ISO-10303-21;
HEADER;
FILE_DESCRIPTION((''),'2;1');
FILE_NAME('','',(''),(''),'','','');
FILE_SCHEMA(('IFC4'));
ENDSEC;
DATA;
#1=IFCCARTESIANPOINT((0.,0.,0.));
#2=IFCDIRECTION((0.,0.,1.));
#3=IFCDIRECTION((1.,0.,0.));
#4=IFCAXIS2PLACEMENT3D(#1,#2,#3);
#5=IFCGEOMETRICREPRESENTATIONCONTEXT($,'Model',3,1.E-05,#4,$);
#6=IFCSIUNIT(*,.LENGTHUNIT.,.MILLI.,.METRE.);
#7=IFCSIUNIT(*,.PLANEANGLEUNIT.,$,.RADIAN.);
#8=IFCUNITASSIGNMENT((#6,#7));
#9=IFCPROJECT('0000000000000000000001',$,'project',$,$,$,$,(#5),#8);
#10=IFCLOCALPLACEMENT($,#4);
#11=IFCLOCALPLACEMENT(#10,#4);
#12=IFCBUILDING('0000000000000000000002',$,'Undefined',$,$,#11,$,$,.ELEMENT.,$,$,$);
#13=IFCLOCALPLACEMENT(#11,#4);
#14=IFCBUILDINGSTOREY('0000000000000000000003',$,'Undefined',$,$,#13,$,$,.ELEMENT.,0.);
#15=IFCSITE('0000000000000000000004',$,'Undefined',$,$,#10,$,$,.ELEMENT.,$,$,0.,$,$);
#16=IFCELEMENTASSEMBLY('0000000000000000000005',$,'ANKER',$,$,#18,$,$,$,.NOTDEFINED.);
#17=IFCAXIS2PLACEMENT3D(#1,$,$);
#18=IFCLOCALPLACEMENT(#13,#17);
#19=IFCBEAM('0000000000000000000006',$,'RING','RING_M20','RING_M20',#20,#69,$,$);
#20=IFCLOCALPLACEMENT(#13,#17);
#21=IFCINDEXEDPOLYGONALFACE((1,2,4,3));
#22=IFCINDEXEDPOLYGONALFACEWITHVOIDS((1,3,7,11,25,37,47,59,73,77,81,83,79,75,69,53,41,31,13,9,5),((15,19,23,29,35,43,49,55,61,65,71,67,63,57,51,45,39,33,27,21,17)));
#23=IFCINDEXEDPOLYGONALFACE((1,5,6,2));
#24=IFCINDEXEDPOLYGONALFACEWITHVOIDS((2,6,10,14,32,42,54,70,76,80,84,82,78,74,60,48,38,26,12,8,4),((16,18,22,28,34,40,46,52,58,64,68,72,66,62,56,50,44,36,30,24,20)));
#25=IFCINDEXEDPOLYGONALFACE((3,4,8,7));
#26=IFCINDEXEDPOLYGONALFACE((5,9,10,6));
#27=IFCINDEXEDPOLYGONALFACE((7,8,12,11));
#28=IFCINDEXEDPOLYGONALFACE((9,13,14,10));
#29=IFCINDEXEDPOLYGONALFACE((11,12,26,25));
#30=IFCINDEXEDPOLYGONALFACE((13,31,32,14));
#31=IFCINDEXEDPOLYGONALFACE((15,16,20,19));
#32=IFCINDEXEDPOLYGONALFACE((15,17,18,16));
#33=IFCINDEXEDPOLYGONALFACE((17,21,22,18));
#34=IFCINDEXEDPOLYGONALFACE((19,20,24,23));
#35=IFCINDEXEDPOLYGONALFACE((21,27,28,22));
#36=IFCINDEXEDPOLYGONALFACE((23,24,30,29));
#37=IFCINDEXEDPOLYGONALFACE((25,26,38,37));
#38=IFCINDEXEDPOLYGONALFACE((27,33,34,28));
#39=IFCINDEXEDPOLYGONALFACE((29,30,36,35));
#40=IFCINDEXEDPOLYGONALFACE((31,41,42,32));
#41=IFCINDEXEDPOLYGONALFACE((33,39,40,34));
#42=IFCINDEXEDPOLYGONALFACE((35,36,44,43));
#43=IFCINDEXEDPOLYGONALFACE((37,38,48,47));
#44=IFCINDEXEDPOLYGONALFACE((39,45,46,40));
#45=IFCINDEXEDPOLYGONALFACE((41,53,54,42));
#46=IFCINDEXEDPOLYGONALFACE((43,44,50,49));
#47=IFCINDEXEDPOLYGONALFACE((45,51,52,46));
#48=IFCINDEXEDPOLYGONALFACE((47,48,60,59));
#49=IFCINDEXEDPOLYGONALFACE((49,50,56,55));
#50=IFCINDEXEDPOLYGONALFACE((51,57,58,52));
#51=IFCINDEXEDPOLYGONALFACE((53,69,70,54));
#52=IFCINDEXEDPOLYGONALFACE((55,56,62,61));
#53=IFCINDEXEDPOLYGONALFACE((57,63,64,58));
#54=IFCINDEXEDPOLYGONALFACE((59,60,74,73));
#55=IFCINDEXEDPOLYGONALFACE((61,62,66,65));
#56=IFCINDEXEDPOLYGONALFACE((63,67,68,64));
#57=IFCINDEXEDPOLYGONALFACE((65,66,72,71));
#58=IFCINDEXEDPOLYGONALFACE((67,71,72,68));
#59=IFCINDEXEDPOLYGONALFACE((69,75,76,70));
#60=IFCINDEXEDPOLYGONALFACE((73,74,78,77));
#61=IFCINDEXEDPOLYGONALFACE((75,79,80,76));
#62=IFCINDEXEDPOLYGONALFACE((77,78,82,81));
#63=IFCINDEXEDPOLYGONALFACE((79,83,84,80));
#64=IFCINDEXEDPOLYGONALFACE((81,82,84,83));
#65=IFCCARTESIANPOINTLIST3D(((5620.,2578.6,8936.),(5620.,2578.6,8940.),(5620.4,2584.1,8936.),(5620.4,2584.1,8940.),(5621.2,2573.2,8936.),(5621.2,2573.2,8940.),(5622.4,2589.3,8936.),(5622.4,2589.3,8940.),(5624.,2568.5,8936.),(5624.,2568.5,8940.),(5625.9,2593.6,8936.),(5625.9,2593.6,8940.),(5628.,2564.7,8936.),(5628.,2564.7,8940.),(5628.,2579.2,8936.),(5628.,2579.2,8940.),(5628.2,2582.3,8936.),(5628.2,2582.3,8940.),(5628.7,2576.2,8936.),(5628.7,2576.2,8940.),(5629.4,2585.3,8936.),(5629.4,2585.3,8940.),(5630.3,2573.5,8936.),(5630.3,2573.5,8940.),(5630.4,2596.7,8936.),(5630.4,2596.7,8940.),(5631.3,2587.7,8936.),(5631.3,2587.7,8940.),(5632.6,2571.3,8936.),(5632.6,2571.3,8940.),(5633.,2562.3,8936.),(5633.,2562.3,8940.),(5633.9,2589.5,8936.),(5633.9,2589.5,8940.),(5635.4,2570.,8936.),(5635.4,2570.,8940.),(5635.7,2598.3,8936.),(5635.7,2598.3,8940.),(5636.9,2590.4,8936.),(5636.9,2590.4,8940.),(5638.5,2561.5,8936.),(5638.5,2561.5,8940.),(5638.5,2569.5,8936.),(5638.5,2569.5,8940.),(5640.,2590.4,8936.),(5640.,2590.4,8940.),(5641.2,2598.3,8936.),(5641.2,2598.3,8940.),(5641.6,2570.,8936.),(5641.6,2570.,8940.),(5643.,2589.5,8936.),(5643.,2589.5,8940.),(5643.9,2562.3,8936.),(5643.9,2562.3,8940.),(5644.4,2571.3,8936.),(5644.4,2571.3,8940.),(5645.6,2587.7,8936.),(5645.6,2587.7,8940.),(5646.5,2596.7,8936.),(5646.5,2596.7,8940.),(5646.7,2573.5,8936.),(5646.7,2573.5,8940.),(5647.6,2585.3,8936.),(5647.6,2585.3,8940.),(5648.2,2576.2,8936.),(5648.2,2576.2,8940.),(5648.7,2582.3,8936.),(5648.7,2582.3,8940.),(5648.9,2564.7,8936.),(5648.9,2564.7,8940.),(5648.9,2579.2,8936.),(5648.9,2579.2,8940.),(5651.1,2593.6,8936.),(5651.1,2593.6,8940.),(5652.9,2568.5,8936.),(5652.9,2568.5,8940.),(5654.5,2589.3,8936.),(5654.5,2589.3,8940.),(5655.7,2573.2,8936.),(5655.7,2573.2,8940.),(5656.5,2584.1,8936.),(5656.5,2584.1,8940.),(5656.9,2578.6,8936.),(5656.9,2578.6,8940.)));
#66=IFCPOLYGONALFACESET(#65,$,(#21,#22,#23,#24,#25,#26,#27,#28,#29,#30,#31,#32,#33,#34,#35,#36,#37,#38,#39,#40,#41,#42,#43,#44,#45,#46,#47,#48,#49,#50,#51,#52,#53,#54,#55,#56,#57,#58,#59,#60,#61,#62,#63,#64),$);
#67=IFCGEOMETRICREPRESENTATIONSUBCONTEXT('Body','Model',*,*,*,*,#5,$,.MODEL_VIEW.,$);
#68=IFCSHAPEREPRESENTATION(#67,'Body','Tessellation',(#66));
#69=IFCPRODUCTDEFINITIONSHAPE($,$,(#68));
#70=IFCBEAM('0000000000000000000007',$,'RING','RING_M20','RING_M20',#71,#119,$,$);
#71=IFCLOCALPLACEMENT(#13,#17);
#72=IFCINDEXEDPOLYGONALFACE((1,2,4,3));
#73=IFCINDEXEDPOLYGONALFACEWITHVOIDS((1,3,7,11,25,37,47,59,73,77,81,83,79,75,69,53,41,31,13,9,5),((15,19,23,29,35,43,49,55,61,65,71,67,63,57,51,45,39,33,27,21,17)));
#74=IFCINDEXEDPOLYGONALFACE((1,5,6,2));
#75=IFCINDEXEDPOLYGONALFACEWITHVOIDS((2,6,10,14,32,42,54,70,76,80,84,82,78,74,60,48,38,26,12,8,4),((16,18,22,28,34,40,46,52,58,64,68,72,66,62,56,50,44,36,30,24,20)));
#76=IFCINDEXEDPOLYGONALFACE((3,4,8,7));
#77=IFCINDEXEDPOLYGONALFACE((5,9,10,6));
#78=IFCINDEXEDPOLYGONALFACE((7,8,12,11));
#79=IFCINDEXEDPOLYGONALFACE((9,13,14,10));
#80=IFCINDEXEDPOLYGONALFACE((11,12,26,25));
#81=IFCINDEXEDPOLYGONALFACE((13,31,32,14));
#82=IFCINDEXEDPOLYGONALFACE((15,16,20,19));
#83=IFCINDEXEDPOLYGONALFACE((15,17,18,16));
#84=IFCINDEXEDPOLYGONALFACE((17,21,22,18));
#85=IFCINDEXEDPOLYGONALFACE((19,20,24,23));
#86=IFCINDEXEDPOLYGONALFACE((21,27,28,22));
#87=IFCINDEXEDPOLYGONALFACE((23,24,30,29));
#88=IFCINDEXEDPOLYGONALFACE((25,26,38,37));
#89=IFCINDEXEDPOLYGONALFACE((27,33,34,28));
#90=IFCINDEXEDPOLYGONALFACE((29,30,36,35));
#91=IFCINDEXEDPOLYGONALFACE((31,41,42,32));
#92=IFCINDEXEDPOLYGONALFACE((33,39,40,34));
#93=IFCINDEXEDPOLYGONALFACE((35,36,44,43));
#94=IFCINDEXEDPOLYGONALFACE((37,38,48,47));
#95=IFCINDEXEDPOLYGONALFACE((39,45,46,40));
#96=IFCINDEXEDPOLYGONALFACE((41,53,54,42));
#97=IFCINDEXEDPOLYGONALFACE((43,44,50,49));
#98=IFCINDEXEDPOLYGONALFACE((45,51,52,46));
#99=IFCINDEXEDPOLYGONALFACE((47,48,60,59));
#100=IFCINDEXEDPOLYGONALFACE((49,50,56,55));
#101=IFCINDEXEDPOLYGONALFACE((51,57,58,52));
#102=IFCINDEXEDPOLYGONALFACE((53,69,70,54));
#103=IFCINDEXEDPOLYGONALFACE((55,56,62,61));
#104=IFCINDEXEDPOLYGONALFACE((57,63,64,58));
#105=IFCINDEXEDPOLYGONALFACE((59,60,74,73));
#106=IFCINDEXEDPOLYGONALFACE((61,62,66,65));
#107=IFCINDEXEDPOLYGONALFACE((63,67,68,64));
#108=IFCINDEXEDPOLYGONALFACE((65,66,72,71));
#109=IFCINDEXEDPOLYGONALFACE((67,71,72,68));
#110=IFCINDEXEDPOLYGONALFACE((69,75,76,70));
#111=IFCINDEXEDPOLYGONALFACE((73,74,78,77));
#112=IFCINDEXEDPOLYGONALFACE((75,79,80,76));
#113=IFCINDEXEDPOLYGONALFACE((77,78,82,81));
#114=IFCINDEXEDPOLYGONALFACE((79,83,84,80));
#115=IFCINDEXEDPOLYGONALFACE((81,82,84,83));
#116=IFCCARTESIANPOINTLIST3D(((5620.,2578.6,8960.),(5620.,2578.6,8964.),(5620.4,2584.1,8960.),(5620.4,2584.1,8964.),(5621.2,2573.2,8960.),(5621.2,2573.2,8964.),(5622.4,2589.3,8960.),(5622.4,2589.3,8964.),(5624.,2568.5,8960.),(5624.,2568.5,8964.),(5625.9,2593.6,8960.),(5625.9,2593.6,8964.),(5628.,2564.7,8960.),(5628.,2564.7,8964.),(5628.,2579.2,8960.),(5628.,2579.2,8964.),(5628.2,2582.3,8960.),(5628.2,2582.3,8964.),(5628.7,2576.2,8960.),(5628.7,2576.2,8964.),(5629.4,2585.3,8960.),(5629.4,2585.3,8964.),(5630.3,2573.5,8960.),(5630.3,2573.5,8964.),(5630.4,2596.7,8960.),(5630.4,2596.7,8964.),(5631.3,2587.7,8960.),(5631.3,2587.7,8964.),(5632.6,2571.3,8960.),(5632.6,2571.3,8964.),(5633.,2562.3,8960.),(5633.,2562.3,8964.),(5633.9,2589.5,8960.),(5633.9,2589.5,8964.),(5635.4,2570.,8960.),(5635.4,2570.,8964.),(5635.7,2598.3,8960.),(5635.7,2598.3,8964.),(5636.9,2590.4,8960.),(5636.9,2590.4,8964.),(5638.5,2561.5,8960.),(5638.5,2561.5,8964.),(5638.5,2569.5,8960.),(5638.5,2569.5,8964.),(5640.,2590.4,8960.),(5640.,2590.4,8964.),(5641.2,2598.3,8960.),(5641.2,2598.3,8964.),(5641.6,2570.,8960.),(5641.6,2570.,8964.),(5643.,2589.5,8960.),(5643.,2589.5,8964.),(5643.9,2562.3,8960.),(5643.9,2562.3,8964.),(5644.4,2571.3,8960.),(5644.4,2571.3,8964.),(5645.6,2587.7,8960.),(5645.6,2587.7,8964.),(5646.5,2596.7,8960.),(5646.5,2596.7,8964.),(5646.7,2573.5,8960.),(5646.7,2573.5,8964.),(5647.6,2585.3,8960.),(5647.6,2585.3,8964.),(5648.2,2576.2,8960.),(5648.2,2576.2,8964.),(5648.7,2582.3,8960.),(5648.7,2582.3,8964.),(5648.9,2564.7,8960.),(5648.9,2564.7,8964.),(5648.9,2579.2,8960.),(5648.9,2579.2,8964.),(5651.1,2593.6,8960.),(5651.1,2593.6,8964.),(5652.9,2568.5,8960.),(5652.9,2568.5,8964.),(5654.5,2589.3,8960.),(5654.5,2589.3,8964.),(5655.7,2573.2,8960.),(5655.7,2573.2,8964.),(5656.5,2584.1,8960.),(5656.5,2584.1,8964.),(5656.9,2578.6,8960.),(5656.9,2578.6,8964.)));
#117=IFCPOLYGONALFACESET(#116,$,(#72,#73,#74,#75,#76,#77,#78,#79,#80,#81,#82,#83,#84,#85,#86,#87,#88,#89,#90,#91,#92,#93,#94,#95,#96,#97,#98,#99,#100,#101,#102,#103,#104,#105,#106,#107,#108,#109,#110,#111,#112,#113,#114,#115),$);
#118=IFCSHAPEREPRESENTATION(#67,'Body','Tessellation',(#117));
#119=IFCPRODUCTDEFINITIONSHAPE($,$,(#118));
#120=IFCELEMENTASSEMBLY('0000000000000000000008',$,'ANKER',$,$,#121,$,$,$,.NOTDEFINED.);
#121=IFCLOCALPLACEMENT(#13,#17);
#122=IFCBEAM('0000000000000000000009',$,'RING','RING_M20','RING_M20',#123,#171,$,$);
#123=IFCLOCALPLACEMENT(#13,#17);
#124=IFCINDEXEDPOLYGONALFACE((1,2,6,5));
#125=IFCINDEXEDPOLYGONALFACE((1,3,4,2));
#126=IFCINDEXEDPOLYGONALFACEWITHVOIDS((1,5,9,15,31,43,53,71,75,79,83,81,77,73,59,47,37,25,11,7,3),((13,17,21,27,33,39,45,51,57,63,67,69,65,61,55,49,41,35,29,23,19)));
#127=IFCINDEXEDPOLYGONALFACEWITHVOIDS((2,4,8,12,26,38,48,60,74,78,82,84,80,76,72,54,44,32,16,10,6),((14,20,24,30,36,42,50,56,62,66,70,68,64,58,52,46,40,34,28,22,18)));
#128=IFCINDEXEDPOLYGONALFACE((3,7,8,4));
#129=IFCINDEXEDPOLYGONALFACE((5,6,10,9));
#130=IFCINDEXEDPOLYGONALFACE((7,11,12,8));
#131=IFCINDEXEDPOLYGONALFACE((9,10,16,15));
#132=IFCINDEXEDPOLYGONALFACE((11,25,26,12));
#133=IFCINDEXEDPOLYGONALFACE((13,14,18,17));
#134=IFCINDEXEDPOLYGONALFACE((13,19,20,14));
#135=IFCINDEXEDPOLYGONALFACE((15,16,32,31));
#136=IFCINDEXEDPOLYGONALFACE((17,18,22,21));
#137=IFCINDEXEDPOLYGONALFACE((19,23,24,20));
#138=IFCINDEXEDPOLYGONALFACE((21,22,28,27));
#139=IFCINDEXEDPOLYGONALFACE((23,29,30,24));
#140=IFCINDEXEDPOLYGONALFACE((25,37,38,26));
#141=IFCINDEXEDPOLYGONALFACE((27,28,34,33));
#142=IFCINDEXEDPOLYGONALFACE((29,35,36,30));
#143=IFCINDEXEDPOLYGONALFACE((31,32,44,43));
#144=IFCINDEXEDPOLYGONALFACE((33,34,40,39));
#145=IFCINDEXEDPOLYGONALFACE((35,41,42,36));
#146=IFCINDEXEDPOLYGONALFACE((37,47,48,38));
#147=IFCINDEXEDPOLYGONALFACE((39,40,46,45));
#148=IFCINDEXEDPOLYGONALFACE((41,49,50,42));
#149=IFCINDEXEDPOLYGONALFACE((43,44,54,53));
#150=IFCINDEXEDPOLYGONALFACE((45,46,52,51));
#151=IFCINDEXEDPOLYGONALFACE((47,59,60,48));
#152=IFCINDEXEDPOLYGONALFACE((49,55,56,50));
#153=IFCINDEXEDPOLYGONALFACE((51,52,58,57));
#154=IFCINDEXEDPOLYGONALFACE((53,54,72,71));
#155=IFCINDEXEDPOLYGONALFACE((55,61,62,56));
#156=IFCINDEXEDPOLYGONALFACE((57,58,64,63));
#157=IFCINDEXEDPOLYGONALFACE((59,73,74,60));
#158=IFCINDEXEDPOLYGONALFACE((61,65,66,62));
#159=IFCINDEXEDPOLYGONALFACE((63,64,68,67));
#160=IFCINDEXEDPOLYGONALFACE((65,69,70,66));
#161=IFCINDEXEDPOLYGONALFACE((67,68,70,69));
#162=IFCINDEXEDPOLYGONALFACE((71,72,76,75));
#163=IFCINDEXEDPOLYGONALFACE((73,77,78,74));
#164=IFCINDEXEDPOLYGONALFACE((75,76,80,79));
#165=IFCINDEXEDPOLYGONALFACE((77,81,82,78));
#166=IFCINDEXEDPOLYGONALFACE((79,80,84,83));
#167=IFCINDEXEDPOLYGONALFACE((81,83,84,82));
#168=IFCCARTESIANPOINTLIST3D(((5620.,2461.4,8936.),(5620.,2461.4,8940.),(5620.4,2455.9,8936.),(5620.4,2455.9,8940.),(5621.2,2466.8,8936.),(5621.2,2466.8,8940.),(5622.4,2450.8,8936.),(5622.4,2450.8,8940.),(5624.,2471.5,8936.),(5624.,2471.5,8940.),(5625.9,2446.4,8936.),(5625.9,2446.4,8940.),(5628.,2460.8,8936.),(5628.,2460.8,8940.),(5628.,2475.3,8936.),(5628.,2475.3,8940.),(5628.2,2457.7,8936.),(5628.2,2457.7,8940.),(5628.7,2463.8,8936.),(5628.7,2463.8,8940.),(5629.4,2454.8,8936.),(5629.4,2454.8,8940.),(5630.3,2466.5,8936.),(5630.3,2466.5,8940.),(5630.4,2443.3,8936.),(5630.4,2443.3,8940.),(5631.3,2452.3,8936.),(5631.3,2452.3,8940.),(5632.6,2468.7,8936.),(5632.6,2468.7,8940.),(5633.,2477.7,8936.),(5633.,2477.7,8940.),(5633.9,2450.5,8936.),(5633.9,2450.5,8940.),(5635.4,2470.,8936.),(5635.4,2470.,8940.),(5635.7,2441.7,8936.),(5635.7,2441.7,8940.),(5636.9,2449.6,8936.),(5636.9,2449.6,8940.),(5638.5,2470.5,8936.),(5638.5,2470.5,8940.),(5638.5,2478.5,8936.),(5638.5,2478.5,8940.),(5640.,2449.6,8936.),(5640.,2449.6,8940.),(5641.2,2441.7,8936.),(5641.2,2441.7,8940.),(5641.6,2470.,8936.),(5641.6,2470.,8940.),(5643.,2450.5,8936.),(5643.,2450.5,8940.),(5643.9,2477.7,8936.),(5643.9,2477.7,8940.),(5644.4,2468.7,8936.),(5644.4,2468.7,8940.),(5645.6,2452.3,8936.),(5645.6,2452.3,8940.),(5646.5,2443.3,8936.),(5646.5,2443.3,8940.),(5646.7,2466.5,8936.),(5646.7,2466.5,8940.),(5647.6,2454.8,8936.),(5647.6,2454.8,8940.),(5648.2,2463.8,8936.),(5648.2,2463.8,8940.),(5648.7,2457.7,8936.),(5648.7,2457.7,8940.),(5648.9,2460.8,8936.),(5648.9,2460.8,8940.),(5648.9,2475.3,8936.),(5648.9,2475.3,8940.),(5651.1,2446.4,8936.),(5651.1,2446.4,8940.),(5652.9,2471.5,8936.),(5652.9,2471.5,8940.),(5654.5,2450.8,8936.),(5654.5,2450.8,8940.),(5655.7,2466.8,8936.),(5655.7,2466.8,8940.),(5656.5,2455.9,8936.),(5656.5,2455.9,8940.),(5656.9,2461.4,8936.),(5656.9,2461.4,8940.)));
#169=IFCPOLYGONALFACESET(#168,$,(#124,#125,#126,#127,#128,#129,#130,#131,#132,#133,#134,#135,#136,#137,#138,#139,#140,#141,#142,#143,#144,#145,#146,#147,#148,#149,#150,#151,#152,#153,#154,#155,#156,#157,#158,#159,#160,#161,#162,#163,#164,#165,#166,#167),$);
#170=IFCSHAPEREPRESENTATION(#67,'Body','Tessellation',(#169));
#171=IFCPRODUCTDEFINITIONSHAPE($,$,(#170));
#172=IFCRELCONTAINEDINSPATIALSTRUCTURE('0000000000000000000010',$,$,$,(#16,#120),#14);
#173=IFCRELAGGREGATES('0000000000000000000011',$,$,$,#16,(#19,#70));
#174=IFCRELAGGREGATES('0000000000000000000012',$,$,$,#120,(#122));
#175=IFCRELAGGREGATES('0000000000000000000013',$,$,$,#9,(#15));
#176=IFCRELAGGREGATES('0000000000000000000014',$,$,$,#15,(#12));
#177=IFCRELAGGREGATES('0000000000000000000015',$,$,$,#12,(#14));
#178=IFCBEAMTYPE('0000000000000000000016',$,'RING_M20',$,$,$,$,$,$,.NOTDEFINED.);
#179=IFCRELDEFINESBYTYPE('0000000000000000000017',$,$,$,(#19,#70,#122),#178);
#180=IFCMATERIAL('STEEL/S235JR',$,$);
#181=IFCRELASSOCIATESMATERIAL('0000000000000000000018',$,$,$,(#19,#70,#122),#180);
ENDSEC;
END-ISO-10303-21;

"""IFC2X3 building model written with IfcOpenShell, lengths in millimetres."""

from ifc_helpers import new_model, si_unit, frame, origin_with_axes, origin_2d_with_axis, place, context, subcontext, project, spatial, hollow_circle, extrude, material, type_object, element, aggregate, save


model = new_model("IFC2X3")

# Units and contexts
model_context = context("Model", 3, precision=1e-05, world=origin_with_axes())
body_context = subcontext(model_context, "Body", "Model", "MODEL_VIEW")
ifc_project = project(units=[si_unit("LENGTHUNIT", "METRE", prefix="MILLI"), si_unit("PLANEANGLEUNIT", "RADIAN")], contexts=[model_context])

# Site, building, storey
site_placement = place(None, origin_with_axes())
site = spatial("IfcSite", under=ifc_project, at=site_placement, Name="Undefined", CompositionType="ELEMENT", RefElevation=0.0)
building_placement = place(site_placement, origin_with_axes())
building = spatial("IfcBuilding", under=site, at=building_placement, Name="Undefined", CompositionType="ELEMENT")
storey_placement = place(building_placement, origin_with_axes())
storey = spatial("IfcBuildingStorey", under=building, at=storey_placement, Name="Undefined", CompositionType="ELEMENT", Elevation=0.0)

# Shared definitions
ifc_material = material(Name="STEEL/S235JR")

# Shared definitions
beam_type_1 = type_object("IfcBeamType", Name="RING_M20", PredefinedType="NOTDEFINED")

# Element assemblies, beams
assembly_1_placement = place(storey_placement, frame((5638.5, 2580.0, 9010.0), z_axis=(0.0, 1.0, 0.0), x_axis=(0.0, 0.0, -1.0)))
assembly_1 = element("IfcElementAssembly", 1, at=assembly_1_placement, inside=storey, Name="ANKER", PredefinedType="NOTDEFINED")
beam_1_placement = place(storey_placement, frame((5638.5, 2580.0, 8940.0), z_axis=(1.0, 0.0, 0.0), x_axis=(0.0, 0.0, -1.0)))
beam_1 = element("IfcBeam", 2, at=beam_1_placement, type_object=beam_type_1, material=ifc_material, Name="RING", Description="RING_M20", ObjectType="RING_M20", context=body_context, shape_type="SweptSolid", body=[
    extrude(hollow_circle(Radius=18.5, WallThickness=8.0, at=origin_2d_with_axis()), frame((4.0, 0.0, 0.0), z_axis=(-1.0, 0.0, 0.0), x_axis=(0.0, -1.0, 0.0)), (0.0, 0.0, 1.0), 4.0),
])
beam_2_placement = place(storey_placement, frame((5638.5, 2580.0, 8964.0), z_axis=(1.0, 0.0, 0.0), x_axis=(0.0, 0.0, -1.0)))
beam_2 = element("IfcBeam", 3, at=beam_2_placement, type_object=beam_type_1, material=ifc_material, Name="RING", Description="RING_M20", ObjectType="RING_M20", context=body_context, shape_type="SweptSolid", body=[
    extrude(hollow_circle(Radius=18.5, WallThickness=8.0, at=origin_2d_with_axis()), frame((4.0, 0.0, 0.0), z_axis=(-1.0, 0.0, 0.0), x_axis=(0.0, -1.0, 0.0)), (0.0, 0.0, 1.0), 4.0),
])
aggregate(assembly_1, [beam_1, beam_2])
assembly_2_placement = place(storey_placement, frame((5638.5, 2460.0, 9010.0), z_axis=(0.0, 1.0, 0.0), x_axis=(0.0, 0.0, -1.0)))
assembly_2 = element("IfcElementAssembly", 4, at=assembly_2_placement, inside=storey, Name="ANKER", PredefinedType="NOTDEFINED")
beam_3_placement = place(storey_placement, frame((5638.5, 2460.0, 8940.0), z_axis=(-1.0, 0.0, 0.0), x_axis=(0.0, 0.0, -1.0)))
beam_3 = element("IfcBeam", 5, at=beam_3_placement, type_object=beam_type_1, material=ifc_material, Name="RING", Description="RING_M20", ObjectType="RING_M20", context=body_context, shape_type="SweptSolid", body=[
    extrude(hollow_circle(Radius=18.5, WallThickness=8.0, at=origin_2d_with_axis()), frame((4.0, 0.0, 0.0), z_axis=(-1.0, 0.0, 0.0), x_axis=(0.0, -1.0, 0.0)), (0.0, 0.0, 1.0), 4.0),
])
aggregate(assembly_2, [beam_3])

save(model, "model.ifc")
